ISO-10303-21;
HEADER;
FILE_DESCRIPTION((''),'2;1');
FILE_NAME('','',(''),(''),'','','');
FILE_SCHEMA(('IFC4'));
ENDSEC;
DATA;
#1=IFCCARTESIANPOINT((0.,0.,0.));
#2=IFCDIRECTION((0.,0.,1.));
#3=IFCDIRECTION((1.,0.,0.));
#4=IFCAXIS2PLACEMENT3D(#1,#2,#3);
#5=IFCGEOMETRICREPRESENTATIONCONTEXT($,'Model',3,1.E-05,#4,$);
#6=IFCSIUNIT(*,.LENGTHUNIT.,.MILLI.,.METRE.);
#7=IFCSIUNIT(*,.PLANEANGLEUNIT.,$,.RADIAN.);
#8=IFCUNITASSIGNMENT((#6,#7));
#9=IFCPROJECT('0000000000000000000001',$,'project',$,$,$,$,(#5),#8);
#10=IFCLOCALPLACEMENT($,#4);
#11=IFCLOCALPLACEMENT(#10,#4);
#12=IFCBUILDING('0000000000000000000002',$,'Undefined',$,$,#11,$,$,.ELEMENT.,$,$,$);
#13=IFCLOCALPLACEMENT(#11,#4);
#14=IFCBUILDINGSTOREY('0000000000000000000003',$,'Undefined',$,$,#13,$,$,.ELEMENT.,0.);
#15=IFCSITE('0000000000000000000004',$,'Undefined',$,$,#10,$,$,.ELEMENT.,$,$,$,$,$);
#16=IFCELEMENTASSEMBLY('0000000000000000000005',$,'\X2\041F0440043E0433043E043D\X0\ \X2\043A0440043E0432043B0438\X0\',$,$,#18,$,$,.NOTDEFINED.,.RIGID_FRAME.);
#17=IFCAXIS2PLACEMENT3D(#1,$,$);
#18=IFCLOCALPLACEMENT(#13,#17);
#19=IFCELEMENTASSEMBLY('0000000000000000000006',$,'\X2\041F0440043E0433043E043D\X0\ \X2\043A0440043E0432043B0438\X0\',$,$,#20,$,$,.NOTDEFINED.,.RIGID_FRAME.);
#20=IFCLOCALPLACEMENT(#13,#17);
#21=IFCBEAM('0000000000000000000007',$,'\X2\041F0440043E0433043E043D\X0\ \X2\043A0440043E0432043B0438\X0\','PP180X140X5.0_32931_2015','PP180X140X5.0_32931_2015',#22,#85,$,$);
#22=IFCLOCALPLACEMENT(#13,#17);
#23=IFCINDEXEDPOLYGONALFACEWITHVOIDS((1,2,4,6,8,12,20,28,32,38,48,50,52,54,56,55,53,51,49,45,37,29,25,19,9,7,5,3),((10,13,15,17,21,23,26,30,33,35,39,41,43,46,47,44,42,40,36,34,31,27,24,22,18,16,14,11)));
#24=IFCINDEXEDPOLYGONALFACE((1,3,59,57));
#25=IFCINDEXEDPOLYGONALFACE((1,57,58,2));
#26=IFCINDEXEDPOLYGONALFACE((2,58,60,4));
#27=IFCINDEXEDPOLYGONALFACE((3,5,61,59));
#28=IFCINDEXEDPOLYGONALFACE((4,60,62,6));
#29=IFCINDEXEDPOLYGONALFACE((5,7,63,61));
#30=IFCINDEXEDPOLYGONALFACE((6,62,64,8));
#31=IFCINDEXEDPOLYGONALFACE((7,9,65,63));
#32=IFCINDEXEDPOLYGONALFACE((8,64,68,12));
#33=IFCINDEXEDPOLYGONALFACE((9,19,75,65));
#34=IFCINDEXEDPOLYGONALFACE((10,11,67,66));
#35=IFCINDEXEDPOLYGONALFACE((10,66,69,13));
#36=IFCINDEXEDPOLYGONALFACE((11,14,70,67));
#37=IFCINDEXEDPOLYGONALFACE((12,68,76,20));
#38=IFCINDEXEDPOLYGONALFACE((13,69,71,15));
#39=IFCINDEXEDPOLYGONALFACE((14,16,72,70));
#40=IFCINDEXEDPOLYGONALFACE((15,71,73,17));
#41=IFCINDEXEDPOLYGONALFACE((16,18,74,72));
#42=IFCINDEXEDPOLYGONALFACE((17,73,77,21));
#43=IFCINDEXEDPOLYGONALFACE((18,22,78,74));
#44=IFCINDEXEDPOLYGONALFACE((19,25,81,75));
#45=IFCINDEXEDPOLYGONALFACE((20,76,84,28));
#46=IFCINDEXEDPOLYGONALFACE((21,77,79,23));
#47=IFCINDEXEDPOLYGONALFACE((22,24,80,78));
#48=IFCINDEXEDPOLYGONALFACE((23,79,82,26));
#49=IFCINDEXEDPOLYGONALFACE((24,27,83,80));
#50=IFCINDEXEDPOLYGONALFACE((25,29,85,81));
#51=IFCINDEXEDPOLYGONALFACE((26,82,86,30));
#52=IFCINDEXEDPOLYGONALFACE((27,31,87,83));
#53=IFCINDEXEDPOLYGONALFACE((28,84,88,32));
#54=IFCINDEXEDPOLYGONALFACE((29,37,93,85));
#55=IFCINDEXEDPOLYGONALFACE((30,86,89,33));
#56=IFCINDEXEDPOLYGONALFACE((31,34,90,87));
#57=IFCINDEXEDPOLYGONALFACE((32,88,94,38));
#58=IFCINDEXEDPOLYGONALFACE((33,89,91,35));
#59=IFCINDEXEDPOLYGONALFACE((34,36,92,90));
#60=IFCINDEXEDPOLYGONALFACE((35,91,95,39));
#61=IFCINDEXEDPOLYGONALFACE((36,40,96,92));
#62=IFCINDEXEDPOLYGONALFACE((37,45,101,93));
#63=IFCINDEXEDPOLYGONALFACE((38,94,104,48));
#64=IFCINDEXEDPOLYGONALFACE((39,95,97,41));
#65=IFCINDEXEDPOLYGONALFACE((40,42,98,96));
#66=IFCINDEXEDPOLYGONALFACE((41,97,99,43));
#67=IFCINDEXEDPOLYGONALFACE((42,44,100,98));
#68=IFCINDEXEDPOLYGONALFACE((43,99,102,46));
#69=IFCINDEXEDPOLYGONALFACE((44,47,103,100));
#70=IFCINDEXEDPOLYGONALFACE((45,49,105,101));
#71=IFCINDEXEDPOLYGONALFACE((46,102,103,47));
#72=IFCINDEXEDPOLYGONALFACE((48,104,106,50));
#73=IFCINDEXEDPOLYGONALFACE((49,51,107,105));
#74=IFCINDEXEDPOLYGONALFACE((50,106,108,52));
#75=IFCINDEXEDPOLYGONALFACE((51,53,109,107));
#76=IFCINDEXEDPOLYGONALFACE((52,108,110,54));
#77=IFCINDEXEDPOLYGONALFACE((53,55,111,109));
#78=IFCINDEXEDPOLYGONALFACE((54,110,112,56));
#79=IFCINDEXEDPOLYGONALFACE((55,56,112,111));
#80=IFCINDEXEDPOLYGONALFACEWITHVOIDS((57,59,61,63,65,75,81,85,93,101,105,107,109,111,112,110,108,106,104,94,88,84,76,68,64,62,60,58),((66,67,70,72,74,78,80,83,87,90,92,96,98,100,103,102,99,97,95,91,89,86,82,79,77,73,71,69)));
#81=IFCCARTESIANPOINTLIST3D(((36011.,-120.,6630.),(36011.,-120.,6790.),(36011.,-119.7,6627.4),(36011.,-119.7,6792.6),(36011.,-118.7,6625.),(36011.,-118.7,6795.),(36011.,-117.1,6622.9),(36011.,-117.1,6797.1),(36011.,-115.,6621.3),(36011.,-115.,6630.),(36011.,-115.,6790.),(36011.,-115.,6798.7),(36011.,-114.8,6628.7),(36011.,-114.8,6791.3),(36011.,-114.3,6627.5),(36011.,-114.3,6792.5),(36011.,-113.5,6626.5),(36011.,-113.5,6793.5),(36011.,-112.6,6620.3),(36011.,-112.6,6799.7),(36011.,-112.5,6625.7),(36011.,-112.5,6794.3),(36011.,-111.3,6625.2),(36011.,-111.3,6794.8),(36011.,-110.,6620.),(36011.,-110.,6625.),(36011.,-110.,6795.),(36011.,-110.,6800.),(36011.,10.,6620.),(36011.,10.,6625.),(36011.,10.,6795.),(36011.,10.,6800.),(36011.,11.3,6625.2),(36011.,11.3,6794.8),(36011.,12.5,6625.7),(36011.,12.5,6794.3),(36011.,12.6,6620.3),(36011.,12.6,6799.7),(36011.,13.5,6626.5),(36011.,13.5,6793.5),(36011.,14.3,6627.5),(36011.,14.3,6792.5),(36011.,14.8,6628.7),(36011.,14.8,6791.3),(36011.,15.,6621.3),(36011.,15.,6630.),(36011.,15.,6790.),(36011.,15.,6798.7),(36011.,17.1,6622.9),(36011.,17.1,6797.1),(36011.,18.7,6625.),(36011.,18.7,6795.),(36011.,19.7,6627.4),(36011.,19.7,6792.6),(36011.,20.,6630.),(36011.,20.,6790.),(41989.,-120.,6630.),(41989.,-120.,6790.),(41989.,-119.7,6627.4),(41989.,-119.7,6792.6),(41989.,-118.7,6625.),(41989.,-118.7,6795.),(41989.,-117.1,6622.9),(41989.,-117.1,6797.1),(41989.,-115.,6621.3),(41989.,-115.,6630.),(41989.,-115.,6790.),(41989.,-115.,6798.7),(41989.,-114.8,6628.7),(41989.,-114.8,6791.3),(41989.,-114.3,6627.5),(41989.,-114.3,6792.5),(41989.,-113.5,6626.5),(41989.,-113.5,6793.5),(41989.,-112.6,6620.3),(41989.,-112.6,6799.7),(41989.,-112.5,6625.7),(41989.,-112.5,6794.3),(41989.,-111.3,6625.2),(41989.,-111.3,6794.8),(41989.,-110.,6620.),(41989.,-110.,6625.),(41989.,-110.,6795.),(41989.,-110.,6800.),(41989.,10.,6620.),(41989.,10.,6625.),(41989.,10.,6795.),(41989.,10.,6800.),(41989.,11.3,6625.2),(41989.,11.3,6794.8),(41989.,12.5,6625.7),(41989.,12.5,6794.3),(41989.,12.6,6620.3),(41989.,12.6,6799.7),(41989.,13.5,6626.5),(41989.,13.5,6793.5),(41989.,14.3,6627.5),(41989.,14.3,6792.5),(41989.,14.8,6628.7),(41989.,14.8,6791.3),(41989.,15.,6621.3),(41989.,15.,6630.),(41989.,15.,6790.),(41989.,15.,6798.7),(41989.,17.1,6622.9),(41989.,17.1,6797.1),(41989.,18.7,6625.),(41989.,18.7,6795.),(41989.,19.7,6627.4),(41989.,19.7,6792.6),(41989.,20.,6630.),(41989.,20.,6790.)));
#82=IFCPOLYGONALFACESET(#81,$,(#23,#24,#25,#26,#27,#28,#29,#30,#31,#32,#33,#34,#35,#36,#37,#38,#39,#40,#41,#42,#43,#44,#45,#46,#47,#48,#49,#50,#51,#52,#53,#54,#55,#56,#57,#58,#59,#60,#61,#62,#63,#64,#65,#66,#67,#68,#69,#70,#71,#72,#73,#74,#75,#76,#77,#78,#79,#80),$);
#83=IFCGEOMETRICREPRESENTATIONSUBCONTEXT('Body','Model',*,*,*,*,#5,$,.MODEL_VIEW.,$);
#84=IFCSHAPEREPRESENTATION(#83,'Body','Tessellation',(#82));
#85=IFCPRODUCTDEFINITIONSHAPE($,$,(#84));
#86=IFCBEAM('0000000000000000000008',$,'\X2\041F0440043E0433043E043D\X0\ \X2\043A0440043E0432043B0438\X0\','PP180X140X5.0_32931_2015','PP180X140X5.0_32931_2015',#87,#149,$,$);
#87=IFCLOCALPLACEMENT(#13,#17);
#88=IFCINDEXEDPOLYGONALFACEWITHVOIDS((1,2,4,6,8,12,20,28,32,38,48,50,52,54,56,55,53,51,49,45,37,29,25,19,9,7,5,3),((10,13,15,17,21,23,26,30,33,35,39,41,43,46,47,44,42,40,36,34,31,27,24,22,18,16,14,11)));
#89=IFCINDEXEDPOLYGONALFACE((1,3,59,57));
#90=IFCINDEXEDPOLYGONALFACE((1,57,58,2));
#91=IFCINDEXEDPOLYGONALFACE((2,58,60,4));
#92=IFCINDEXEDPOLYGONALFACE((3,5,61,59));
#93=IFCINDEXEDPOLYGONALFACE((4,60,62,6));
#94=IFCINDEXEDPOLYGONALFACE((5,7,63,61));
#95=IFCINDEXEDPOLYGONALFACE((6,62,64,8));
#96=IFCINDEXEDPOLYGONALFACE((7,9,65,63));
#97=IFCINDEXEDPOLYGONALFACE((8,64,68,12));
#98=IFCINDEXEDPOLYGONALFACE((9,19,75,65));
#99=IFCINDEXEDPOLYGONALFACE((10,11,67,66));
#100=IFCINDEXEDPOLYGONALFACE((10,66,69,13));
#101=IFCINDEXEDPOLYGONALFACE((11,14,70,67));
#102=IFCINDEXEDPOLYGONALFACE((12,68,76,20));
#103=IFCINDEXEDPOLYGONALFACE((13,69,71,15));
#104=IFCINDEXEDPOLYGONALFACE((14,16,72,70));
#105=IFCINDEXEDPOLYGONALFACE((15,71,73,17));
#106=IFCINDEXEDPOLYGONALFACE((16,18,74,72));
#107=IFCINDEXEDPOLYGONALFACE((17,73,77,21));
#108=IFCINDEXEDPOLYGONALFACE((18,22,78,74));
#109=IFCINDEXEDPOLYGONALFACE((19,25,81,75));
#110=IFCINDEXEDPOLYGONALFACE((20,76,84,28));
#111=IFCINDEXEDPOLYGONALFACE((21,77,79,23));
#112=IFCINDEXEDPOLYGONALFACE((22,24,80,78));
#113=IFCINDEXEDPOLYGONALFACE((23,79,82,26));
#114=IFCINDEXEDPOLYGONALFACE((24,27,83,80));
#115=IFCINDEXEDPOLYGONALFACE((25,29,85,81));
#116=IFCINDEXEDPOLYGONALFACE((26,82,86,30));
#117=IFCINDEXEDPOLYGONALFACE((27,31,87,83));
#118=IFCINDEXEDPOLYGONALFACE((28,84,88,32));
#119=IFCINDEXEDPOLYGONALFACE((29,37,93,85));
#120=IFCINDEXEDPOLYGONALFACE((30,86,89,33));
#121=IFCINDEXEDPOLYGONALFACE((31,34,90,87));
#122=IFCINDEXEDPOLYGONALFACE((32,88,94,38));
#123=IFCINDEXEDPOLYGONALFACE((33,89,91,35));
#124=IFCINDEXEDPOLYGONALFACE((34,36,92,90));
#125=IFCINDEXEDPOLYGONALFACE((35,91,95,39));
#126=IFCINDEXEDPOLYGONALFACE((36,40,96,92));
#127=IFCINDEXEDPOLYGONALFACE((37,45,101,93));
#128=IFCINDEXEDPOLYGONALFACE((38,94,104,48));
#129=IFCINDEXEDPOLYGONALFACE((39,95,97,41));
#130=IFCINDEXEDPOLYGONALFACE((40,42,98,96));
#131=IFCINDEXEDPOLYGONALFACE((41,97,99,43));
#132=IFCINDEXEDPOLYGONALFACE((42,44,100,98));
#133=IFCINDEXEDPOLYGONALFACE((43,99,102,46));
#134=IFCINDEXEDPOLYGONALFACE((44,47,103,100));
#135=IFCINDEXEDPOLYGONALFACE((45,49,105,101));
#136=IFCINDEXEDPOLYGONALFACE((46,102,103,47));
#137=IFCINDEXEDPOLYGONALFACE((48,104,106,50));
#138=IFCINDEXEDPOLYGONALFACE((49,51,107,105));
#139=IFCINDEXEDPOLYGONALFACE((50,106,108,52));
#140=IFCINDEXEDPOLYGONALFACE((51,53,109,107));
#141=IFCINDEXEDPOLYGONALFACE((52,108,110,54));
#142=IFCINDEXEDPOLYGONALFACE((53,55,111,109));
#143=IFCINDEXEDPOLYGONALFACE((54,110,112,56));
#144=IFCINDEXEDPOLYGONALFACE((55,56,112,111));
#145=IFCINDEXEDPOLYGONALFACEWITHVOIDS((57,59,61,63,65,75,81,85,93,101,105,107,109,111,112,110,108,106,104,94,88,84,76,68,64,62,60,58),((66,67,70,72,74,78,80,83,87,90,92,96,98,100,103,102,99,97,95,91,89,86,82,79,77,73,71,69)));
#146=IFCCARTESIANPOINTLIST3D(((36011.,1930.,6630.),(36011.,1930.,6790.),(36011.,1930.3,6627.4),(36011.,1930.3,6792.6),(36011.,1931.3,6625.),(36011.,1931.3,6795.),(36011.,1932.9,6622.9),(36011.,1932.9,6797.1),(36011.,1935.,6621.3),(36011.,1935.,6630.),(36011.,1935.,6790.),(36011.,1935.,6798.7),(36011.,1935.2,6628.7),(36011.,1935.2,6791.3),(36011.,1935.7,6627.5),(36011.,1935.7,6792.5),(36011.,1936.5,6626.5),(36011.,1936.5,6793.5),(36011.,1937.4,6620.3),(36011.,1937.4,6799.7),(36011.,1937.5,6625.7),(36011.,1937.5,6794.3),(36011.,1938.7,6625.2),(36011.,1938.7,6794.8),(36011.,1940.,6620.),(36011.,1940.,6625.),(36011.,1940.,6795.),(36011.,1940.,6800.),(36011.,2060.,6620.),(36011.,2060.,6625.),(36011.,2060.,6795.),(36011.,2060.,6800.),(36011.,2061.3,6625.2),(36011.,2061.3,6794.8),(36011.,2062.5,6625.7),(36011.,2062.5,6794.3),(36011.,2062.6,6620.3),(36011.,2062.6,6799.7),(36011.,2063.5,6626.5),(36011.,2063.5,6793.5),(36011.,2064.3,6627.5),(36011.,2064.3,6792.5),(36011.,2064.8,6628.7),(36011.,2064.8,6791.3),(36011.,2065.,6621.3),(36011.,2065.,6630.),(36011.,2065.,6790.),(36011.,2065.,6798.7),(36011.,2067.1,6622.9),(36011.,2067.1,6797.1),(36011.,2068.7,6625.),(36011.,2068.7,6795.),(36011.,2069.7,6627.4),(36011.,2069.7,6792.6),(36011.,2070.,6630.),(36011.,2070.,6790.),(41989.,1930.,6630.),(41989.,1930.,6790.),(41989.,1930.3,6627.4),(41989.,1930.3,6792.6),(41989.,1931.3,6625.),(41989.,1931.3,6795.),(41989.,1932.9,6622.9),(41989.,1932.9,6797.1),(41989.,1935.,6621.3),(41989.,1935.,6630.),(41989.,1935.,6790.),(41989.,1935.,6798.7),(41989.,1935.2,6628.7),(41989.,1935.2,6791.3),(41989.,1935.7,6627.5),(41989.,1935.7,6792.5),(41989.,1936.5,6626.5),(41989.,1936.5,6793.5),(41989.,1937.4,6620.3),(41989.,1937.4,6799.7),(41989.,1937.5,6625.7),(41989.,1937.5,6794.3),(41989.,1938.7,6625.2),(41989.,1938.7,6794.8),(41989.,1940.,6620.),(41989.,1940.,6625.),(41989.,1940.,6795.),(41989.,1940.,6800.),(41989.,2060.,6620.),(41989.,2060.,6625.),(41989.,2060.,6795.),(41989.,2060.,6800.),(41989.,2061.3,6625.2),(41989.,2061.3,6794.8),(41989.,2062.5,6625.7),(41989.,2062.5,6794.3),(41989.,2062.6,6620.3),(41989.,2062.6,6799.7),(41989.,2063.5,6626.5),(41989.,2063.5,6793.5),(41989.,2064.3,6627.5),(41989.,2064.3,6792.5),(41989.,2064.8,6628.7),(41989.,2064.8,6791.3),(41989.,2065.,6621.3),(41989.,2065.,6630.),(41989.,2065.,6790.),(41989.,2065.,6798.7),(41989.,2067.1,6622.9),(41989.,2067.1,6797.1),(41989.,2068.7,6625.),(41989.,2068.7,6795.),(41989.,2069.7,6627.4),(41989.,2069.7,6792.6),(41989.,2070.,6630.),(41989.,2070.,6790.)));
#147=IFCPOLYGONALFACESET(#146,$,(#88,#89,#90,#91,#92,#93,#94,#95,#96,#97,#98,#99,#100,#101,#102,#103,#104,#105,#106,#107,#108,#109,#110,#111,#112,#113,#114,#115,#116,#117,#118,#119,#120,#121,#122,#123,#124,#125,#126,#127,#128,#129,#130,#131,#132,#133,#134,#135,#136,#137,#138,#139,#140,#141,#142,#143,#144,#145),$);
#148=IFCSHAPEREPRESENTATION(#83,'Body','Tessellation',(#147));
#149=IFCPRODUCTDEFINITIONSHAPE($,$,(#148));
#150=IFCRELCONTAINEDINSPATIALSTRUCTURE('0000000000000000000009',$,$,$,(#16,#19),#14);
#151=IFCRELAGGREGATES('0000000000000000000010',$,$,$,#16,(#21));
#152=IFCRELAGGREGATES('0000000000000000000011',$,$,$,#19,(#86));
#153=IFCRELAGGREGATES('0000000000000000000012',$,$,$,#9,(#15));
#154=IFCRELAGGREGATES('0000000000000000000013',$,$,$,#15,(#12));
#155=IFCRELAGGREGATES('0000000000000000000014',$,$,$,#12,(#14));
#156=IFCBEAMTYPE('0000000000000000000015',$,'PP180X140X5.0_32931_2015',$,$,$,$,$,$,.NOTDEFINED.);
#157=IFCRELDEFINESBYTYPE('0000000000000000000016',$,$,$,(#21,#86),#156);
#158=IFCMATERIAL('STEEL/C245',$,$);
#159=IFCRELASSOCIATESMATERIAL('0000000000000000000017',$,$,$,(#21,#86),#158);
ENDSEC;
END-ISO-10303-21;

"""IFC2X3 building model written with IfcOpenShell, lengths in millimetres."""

from ifc_helpers import new_model, si_unit, frame, origin_with_axes, origin_2d_with_axis, place, context, subcontext, project, spatial, hollow_rectangle, extrude, clip, halfspace, material, type_object, element, aggregate, save


model = new_model("IFC2X3")

# Units and contexts
model_context = context("Model", 3, precision=1e-05, world=origin_with_axes())
body_context = subcontext(model_context, "Body", "Model", "MODEL_VIEW")
ifc_project = project(units=[si_unit("LENGTHUNIT", "METRE", prefix="MILLI"), si_unit("PLANEANGLEUNIT", "RADIAN")], contexts=[model_context])

# Site, building, storey
site_placement = place(None, origin_with_axes())
site = spatial("IfcSite", under=ifc_project, at=site_placement, Name="Undefined", CompositionType="ELEMENT")
building_placement = place(site_placement, origin_with_axes())
building = spatial("IfcBuilding", under=site, at=building_placement, Name="Undefined", CompositionType="ELEMENT")
storey_placement = place(building_placement, origin_with_axes())
storey = spatial("IfcBuildingStorey", under=building, at=storey_placement, Name="Undefined", CompositionType="ELEMENT", Elevation=0.0)

# Element assembly
assembly_1_placement = place(storey_placement, origin_with_axes())
assembly_1 = element("IfcElementAssembly", 1, at=assembly_1_placement, inside=storey, Name="Прогон кровли", AssemblyPlace="NOTDEFINED", PredefinedType="RIGID_FRAME")
ifc_material_1 = material(Name="STEEL/C245")

# Element assembly
assembly_2_placement = place(storey_placement, origin_with_axes())
assembly_2 = element("IfcElementAssembly", 2, at=assembly_2_placement, inside=storey, Name="Прогон кровли", AssemblyPlace="NOTDEFINED", PredefinedType="RIGID_FRAME")

# Beams
beam_type_1 = type_object("IfcBeamType", Name="PP180X140X5.0_32931_2015", PredefinedType="NOTDEFINED")
beam_1_placement = place(assembly_1_placement, frame((36013.0, -50.0, 6710.0), z_axis=(0.0, 0.0, 1.0), x_axis=(1.0, 0.0, 0.0)))
beam_1 = element("IfcBeam", 3, at=beam_1_placement, type_object=beam_type_1, material=ifc_material_1, Name="Прогон кровли", Description="PP180X140X5.0_32931_2015", ObjectType="PP180X140X5.0_32931_2015", context=body_context, shape_type="Clipping", body=[
    clip(clip(extrude(hollow_rectangle(XDim=140.0, YDim=180.0, WallThickness=5.0, InnerFilletRadius=5.0, OuterFilletRadius=10.0, at=origin_2d_with_axis()), frame((5976.0, 0.0, 0.0), z_axis=(-1.0, 0.0, 0.0), x_axis=(0.0, -1.0, 0.0)), (0.0, 0.0, 1.0), 5978.0), halfspace(frame((5976.0, 0.0, -90.0), z_axis=(-1.0, 0.0, 0.0), x_axis=(0.0, 1.0, 0.0)), True)), halfspace(frame((-2.0, 0.0, -90.0), z_axis=(1.0, 0.0, 0.0), x_axis=(0.0, -1.0, 0.0)), True)),
])
beam_2_placement = place(assembly_2_placement, frame((36005.0, 2000.0, 6710.0), z_axis=(0.0, 0.0, 1.0), x_axis=(1.0, 0.0, 0.0)))
beam_2 = element("IfcBeam", 4, at=beam_2_placement, type_object=beam_type_1, material=ifc_material_1, Name="Прогон кровли", Description="PP180X140X5.0_32931_2015", ObjectType="PP180X140X5.0_32931_2015", context=body_context, shape_type="Clipping", body=[
    clip(clip(extrude(hollow_rectangle(XDim=140.0, YDim=180.0, WallThickness=5.0, InnerFilletRadius=5.0, OuterFilletRadius=10.0, at=origin_2d_with_axis()), frame((5984.0, 0.0, 0.0), z_axis=(-1.0, 0.0, 0.0), x_axis=(0.0, -1.0, 0.0)), (0.0, 0.0, 1.0), 5978.0), halfspace(frame((5984.0, 0.0, -90.0), z_axis=(-1.0, 0.0, 0.0), x_axis=(0.0, 1.0, 0.0)), True)), halfspace(frame((6.0, 0.0, -90.0), z_axis=(1.0, 0.0, 0.0), x_axis=(0.0, -1.0, 0.0)), True)),
])

aggregate(assembly_1, [beam_1])
aggregate(assembly_2, [beam_2])

save(model, "model.ifc")
